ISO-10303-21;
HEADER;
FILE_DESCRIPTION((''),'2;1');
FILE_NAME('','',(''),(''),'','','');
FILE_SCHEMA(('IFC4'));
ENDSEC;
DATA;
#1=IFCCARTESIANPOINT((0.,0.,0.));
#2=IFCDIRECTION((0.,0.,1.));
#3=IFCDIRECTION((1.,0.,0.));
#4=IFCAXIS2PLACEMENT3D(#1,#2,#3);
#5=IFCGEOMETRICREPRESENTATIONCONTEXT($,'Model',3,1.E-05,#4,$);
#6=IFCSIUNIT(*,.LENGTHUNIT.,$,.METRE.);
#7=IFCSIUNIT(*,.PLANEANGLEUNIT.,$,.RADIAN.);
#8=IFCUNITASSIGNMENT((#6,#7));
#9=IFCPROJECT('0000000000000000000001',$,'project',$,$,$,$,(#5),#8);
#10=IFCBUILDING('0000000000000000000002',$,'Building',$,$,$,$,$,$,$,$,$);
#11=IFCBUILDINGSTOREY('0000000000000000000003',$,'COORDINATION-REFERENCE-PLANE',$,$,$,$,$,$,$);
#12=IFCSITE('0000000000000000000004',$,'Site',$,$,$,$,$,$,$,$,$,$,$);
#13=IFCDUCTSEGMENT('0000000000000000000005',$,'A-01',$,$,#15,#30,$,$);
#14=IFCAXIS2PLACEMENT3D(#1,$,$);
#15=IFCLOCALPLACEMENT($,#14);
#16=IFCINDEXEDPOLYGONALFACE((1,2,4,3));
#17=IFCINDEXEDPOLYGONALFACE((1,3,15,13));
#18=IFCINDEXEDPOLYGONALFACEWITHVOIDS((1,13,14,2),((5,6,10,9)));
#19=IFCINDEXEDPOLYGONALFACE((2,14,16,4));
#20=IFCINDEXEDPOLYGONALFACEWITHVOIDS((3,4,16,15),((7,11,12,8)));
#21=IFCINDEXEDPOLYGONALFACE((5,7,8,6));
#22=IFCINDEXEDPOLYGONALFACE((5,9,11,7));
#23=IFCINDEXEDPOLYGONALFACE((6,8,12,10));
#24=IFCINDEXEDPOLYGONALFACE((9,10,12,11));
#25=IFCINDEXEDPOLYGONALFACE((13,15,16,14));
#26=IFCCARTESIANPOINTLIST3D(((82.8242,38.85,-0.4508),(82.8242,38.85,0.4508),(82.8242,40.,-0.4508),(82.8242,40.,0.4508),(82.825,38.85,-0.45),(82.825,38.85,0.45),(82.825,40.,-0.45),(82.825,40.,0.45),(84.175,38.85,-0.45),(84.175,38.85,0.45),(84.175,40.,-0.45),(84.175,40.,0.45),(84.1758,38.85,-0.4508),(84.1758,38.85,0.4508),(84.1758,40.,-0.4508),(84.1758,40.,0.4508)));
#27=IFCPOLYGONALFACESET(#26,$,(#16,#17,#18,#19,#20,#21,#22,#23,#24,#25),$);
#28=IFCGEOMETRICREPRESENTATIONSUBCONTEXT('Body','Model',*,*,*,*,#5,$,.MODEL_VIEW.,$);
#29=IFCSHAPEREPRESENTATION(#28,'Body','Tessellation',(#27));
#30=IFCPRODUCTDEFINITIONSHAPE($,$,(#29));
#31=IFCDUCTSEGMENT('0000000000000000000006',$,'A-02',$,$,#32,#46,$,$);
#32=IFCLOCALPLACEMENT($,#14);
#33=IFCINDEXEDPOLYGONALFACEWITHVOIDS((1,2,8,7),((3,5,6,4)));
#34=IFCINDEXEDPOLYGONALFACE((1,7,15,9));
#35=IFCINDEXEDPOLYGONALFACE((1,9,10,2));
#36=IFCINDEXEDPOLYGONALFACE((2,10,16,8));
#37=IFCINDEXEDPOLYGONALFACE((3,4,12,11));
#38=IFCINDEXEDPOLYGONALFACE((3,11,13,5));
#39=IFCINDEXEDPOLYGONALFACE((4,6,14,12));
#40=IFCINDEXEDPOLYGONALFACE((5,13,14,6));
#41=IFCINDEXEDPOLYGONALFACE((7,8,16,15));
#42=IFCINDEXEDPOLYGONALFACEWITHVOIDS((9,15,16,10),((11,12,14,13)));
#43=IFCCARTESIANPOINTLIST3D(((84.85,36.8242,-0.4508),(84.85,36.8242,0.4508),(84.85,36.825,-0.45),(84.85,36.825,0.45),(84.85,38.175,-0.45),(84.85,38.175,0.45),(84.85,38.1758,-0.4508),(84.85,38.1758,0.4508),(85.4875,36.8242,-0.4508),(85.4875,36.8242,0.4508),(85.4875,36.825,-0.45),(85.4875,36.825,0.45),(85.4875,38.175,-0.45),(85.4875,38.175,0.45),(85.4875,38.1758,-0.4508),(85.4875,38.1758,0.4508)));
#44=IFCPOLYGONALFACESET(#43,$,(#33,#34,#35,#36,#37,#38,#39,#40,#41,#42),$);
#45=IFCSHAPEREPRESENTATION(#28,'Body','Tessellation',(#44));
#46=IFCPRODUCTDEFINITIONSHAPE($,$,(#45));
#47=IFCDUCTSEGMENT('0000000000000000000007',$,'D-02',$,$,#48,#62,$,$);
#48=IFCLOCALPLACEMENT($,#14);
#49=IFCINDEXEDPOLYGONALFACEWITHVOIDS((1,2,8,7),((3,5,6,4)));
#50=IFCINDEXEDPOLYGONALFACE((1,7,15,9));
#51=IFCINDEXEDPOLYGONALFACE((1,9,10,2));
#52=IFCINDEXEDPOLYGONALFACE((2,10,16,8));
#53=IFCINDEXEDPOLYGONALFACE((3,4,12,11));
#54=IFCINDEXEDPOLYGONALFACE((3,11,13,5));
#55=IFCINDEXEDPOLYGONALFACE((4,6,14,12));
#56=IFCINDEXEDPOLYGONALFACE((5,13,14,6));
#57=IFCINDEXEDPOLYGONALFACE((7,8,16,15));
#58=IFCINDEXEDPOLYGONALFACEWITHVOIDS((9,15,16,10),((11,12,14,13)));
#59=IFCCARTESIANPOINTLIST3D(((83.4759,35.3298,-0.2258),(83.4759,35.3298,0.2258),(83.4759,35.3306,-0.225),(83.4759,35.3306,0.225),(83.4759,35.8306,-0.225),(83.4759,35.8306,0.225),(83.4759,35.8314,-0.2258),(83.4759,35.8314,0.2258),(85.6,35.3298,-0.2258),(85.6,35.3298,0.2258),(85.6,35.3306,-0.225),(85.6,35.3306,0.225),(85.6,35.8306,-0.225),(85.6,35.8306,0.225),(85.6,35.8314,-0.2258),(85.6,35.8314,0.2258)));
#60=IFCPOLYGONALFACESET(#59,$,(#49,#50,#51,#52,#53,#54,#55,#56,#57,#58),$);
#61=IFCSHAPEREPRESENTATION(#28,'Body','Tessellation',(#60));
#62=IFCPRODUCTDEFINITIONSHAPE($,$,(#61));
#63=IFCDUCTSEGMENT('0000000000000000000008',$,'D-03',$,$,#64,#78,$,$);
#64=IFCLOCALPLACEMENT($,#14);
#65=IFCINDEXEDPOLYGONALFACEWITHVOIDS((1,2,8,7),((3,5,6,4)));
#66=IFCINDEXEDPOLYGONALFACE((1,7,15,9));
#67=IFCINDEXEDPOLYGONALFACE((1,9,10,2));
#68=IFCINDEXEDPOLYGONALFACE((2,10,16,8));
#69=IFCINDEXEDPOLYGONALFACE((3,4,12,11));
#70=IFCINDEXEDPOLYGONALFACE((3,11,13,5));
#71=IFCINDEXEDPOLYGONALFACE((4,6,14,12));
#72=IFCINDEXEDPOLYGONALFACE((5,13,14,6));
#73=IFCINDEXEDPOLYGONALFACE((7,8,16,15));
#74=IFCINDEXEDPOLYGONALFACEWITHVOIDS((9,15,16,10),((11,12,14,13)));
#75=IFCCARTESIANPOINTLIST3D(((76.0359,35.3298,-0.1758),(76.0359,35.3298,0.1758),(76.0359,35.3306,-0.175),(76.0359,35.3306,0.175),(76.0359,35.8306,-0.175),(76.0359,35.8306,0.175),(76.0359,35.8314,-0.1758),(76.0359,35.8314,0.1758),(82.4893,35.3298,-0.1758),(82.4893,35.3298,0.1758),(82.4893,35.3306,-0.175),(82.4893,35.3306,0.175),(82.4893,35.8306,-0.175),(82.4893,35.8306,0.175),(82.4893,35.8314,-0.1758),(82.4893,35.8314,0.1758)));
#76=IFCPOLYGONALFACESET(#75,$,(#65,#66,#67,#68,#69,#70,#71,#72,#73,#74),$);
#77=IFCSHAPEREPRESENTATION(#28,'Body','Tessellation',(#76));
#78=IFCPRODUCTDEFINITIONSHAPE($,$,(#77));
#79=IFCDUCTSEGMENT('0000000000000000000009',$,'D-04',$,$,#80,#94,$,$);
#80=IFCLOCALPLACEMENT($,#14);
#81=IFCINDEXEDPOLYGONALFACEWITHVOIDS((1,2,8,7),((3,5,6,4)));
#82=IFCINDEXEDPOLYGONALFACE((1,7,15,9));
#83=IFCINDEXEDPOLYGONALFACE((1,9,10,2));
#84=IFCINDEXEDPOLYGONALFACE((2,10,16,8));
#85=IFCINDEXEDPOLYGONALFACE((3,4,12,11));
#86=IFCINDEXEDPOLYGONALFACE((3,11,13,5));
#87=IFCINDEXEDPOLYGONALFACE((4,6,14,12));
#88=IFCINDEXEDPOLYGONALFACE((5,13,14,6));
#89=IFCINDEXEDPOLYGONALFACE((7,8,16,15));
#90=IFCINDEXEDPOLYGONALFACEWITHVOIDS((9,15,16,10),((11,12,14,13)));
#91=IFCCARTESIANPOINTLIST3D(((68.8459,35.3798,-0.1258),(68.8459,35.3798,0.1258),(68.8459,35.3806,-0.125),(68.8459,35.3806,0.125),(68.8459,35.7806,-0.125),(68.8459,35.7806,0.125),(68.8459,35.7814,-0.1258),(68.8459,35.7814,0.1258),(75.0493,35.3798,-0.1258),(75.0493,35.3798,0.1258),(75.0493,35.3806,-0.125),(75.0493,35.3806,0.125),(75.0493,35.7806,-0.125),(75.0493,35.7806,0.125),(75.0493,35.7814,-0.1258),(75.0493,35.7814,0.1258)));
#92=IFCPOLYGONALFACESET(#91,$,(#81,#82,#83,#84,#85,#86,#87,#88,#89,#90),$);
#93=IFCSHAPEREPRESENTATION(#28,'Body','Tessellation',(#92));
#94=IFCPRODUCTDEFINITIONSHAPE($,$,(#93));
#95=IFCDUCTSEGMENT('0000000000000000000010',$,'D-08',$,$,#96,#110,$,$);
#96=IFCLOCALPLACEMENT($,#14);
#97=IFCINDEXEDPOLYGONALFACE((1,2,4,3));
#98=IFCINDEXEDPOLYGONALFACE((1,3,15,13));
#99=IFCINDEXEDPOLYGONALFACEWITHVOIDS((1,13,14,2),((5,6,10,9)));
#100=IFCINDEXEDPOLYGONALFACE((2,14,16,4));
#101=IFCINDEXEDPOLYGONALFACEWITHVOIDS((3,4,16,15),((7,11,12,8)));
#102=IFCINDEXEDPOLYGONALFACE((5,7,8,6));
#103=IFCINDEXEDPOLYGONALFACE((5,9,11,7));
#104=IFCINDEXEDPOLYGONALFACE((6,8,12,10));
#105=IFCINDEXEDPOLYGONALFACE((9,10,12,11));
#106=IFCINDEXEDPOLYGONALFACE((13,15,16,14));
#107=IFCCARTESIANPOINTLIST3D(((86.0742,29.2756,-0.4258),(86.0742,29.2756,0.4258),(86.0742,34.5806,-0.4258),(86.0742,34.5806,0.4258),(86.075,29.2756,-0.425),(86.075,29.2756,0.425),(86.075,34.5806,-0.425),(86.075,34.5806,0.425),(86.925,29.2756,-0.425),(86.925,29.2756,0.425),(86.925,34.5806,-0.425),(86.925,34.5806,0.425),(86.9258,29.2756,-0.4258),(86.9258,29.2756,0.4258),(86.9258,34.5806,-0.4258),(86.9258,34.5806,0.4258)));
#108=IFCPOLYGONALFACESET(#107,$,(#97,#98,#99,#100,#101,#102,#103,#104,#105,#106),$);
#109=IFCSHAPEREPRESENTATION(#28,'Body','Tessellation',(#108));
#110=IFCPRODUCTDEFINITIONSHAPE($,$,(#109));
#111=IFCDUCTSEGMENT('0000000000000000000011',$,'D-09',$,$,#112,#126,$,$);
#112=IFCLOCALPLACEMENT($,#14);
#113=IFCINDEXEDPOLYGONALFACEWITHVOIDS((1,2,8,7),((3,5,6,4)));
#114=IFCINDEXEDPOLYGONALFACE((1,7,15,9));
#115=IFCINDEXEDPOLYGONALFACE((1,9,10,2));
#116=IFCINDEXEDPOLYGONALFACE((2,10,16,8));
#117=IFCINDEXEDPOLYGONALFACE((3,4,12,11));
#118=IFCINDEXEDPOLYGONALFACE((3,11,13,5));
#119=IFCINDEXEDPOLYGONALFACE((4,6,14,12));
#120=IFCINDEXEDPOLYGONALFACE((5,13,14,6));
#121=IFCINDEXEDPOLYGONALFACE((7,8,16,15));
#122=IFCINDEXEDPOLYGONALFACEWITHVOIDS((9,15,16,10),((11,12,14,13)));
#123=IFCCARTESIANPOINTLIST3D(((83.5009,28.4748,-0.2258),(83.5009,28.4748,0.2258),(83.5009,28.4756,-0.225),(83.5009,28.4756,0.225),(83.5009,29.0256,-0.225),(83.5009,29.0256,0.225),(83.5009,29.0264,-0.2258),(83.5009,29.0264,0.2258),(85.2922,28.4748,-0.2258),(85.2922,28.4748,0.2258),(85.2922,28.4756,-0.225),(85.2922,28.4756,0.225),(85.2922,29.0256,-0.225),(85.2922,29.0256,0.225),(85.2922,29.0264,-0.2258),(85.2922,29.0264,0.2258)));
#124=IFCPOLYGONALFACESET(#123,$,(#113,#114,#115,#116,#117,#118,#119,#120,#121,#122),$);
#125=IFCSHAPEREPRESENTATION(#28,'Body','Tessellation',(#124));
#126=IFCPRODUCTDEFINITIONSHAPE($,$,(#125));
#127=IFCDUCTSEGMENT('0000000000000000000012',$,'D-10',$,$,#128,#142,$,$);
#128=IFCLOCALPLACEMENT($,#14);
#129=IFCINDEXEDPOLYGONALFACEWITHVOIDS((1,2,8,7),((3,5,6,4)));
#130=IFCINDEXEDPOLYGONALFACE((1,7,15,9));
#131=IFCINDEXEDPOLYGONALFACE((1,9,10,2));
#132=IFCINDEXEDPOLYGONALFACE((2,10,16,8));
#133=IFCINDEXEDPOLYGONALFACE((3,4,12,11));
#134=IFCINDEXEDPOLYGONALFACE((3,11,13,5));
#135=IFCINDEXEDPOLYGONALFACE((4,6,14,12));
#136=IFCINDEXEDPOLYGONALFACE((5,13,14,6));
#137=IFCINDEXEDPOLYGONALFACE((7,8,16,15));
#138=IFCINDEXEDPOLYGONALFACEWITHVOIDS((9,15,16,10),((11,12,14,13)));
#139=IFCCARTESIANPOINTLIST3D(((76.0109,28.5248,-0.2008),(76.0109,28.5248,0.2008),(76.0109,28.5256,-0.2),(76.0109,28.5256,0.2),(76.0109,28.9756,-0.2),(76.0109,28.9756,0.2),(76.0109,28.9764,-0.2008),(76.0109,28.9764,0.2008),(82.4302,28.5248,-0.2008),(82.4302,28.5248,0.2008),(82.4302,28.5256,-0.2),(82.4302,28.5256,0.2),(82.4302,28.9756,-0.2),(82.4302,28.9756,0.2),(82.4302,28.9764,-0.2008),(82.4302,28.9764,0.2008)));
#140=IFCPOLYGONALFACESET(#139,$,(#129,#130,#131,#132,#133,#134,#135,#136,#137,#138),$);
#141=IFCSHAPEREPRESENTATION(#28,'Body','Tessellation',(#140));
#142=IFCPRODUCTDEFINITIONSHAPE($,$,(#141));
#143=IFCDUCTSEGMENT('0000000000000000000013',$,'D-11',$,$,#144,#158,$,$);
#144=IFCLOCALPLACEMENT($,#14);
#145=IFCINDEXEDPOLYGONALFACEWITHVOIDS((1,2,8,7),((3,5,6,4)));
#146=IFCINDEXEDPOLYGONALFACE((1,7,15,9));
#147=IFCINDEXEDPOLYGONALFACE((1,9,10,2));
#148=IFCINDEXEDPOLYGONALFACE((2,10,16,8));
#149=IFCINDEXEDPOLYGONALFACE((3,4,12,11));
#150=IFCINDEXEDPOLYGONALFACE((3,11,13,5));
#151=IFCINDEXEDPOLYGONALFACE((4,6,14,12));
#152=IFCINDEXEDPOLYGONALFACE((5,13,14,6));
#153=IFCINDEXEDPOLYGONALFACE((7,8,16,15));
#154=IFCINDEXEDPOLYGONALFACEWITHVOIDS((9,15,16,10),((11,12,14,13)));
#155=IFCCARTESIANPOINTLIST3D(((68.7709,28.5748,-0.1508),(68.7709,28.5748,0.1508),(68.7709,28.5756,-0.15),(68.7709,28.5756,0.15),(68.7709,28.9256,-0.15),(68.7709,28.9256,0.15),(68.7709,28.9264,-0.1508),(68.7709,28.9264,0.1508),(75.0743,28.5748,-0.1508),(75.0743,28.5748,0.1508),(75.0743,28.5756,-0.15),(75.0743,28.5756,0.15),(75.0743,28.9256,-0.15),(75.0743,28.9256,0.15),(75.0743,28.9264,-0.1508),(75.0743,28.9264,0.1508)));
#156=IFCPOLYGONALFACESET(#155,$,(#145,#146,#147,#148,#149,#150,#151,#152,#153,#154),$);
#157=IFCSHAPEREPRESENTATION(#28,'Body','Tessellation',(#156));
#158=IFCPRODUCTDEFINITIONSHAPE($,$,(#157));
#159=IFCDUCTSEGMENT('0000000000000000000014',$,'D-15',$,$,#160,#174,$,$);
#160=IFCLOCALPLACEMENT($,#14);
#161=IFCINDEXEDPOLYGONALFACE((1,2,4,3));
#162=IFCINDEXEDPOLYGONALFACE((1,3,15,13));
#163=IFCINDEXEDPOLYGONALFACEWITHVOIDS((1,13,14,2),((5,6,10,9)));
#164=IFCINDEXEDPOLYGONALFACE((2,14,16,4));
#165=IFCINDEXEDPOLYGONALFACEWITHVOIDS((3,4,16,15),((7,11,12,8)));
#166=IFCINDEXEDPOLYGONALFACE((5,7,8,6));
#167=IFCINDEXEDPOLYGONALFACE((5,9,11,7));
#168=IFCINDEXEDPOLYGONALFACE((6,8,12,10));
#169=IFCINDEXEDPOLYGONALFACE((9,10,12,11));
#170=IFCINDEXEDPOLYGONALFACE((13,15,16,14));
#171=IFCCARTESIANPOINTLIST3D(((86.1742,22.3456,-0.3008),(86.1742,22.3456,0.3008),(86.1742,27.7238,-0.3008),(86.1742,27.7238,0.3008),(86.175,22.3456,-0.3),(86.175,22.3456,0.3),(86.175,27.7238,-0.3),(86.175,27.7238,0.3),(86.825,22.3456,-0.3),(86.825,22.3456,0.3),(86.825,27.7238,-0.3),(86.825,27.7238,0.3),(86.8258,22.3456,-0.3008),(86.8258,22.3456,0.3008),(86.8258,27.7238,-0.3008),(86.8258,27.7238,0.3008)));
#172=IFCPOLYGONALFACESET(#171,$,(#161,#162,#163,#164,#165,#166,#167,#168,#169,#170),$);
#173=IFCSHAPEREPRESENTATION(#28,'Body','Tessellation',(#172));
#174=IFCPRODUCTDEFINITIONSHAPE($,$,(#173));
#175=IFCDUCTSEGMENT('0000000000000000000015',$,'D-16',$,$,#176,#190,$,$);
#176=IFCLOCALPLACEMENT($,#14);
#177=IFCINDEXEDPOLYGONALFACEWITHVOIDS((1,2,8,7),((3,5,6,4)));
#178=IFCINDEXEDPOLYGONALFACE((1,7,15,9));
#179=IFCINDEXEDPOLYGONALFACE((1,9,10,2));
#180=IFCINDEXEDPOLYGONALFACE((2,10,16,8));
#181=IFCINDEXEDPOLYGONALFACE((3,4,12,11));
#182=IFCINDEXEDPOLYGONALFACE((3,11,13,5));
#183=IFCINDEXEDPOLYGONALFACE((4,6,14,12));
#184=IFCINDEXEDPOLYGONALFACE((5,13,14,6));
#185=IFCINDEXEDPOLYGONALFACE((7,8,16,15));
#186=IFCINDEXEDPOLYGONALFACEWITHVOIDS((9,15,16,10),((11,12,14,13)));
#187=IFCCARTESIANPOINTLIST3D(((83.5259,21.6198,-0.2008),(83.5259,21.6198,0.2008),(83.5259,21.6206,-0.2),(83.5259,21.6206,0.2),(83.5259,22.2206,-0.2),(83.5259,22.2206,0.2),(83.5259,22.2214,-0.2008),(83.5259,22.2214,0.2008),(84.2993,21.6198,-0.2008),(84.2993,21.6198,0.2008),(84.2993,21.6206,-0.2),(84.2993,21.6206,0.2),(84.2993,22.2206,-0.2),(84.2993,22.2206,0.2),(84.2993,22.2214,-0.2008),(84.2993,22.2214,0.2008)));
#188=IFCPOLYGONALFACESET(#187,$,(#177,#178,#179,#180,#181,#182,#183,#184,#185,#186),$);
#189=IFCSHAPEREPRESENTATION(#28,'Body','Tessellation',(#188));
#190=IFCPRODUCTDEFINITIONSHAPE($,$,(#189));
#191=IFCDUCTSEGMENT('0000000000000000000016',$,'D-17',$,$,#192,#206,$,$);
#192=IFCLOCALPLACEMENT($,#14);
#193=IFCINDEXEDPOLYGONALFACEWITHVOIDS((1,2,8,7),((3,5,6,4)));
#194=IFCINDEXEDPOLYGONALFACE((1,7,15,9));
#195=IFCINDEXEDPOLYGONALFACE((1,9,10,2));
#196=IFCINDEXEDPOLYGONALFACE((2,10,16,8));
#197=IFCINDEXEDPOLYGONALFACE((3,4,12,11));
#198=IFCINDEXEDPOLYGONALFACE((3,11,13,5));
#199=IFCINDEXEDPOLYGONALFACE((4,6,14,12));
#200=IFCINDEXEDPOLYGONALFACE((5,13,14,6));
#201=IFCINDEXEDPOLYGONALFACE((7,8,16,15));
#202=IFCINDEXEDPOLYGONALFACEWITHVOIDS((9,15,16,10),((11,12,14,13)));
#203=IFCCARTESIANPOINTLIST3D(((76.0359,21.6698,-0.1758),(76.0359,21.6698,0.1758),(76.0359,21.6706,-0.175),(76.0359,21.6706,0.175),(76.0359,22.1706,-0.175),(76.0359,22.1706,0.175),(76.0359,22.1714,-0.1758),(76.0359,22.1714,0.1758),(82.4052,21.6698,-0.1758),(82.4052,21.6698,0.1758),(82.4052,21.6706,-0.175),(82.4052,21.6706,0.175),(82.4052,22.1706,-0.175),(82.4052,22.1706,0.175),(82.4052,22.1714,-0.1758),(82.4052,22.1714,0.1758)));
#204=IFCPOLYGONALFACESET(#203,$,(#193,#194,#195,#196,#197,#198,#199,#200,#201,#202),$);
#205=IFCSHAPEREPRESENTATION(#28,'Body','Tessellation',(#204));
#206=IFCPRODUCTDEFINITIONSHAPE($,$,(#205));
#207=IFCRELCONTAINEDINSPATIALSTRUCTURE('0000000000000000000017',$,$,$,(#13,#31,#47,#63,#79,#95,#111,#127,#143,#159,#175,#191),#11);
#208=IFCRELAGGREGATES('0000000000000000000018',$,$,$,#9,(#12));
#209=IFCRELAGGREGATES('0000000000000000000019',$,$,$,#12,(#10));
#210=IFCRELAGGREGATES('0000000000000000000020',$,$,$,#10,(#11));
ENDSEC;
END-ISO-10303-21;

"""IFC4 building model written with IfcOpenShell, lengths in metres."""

from ifc_helpers import new_model, si_unit, frame, origin, origin_with_axes, place, context, subcontext, project, spatial, hollow_rectangle, extrude, element, save


model = new_model("IFC4")

# Units and contexts
model_context = context("Model", 3, precision=1e-05, world=origin_with_axes())
body_context = subcontext(model_context, "Body", "Model", "MODEL_VIEW")
ifc_project = project(units=[si_unit("LENGTHUNIT", "METRE"), si_unit("PLANEANGLEUNIT", "RADIAN")], contexts=[model_context])

# Site, building, storey
site = spatial("IfcSite", under=ifc_project, Name="Site")
building = spatial("IfcBuilding", under=site, Name="Building")
storey = spatial("IfcBuildingStorey", under=building, Name="COORDINATION-REFERENCE-PLANE")

# Duct segments
duct_segment_1_placement = place(None, frame((83.5, 38.85, 0.0), z_axis=(0.0, 1.0, 0.0), x_axis=(1.0, 0.0, 0.0)))
element("IfcDuctSegment", 1, at=duct_segment_1_placement, inside=storey, Name="A-01", context=body_context, shape_type="SweptSolid", body=[
    extrude(hollow_rectangle(XDim=1.3516, YDim=0.9016, WallThickness=0.0008), origin(), (0.0, 0.0, 1.0), 1.15),
])
duct_segment_2_placement = place(None, frame((84.85, 37.5, 0.0), z_axis=(1.0, 0.0, 0.0), x_axis=(0.0, 1.0, 0.0)))
element("IfcDuctSegment", 2, at=duct_segment_2_placement, inside=storey, Name="A-02", context=body_context, shape_type="SweptSolid", body=[
    extrude(hollow_rectangle(XDim=1.3516, YDim=0.9016, WallThickness=0.0008), origin(), (0.0, 0.0, 1.0), 0.6375),
])
duct_segment_3_placement = place(None, frame((83.4759, 35.5806, 0.0), z_axis=(1.0, 0.0, 0.0), x_axis=(0.0, 1.0, 0.0)))
element("IfcDuctSegment", 3, at=duct_segment_3_placement, inside=storey, Name="D-02", context=body_context, shape_type="SweptSolid", body=[
    extrude(hollow_rectangle(XDim=0.5016, YDim=0.4516, WallThickness=0.0008), origin(), (0.0, 0.0, 1.0), 2.1241),
])
duct_segment_4_placement = place(None, frame((76.0359, 35.5806, 0.0), z_axis=(1.0, 0.0, 0.0), x_axis=(0.0, 1.0, 0.0)))
element("IfcDuctSegment", 4, at=duct_segment_4_placement, inside=storey, Name="D-03", context=body_context, shape_type="SweptSolid", body=[
    extrude(hollow_rectangle(XDim=0.5016, YDim=0.3516, WallThickness=0.0008), origin(), (0.0, 0.0, 1.0), 6.4534),
])
duct_segment_5_placement = place(None, frame((68.8459, 35.5806, 0.0), z_axis=(1.0, 0.0, 0.0), x_axis=(0.0, 1.0, 0.0)))
element("IfcDuctSegment", 5, at=duct_segment_5_placement, inside=storey, Name="D-04", context=body_context, shape_type="SweptSolid", body=[
    extrude(hollow_rectangle(XDim=0.4016, YDim=0.2516, WallThickness=0.0008), origin(), (0.0, 0.0, 1.0), 6.2034),
])
duct_segment_6_placement = place(None, frame((86.5, 29.2756, 0.0), z_axis=(0.0, 1.0, 0.0), x_axis=(1.0, 0.0, 0.0)))
element("IfcDuctSegment", 6, at=duct_segment_6_placement, inside=storey, Name="D-08", context=body_context, shape_type="SweptSolid", body=[
    extrude(hollow_rectangle(XDim=0.8516, YDim=0.8516, WallThickness=0.0008), origin(), (0.0, 0.0, 1.0), 5.305),
])
duct_segment_7_placement = place(None, frame((83.5009, 28.7506, 0.0), z_axis=(1.0, 0.0, 0.0), x_axis=(0.0, 1.0, 0.0)))
element("IfcDuctSegment", 7, at=duct_segment_7_placement, inside=storey, Name="D-09", context=body_context, shape_type="SweptSolid", body=[
    extrude(hollow_rectangle(XDim=0.5516, YDim=0.4516, WallThickness=0.0008), origin(), (0.0, 0.0, 1.0), 1.7912),
])
duct_segment_8_placement = place(None, frame((76.0109, 28.7506, 0.0), z_axis=(1.0, 0.0, 0.0), x_axis=(0.0, 1.0, 0.0)))
element("IfcDuctSegment", 8, at=duct_segment_8_placement, inside=storey, Name="D-10", context=body_context, shape_type="SweptSolid", body=[
    extrude(hollow_rectangle(XDim=0.4516, YDim=0.4016, WallThickness=0.0008), origin(), (0.0, 0.0, 1.0), 6.4193),
])
duct_segment_9_placement = place(None, frame((68.7709, 28.7506, 0.0), z_axis=(1.0, 0.0, 0.0), x_axis=(0.0, 1.0, 0.0)))
element("IfcDuctSegment", 9, at=duct_segment_9_placement, inside=storey, Name="D-11", context=body_context, shape_type="SweptSolid", body=[
    extrude(hollow_rectangle(XDim=0.3516, YDim=0.3016, WallThickness=0.0008), origin(), (0.0, 0.0, 1.0), 6.3034),
])
duct_segment_10_placement = place(None, frame((86.5, 22.3456, 0.0), z_axis=(0.0, 1.0, 0.0), x_axis=(1.0, 0.0, 0.0)))
element("IfcDuctSegment", 10, at=duct_segment_10_placement, inside=storey, Name="D-15", context=body_context, shape_type="SweptSolid", body=[
    extrude(hollow_rectangle(XDim=0.6516, YDim=0.6016, WallThickness=0.0008), origin(), (0.0, 0.0, 1.0), 5.3782),
])
duct_segment_11_placement = place(None, frame((83.5259, 21.9206, 0.0), z_axis=(1.0, 0.0, 0.0), x_axis=(0.0, 1.0, 0.0)))
element("IfcDuctSegment", 11, at=duct_segment_11_placement, inside=storey, Name="D-16", context=body_context, shape_type="SweptSolid", body=[
    extrude(hollow_rectangle(XDim=0.6016, YDim=0.4016, WallThickness=0.0008), origin(), (0.0, 0.0, 1.0), 0.7733),
])
duct_segment_12_placement = place(None, frame((76.0359, 21.9206, 0.0), z_axis=(1.0, 0.0, 0.0), x_axis=(0.0, 1.0, 0.0)))
element("IfcDuctSegment", 12, at=duct_segment_12_placement, inside=storey, Name="D-17", context=body_context, shape_type="SweptSolid", body=[
    extrude(hollow_rectangle(XDim=0.5016, YDim=0.3516, WallThickness=0.0008), origin(), (0.0, 0.0, 1.0), 6.3693),
])

save(model, "model.ifc")
